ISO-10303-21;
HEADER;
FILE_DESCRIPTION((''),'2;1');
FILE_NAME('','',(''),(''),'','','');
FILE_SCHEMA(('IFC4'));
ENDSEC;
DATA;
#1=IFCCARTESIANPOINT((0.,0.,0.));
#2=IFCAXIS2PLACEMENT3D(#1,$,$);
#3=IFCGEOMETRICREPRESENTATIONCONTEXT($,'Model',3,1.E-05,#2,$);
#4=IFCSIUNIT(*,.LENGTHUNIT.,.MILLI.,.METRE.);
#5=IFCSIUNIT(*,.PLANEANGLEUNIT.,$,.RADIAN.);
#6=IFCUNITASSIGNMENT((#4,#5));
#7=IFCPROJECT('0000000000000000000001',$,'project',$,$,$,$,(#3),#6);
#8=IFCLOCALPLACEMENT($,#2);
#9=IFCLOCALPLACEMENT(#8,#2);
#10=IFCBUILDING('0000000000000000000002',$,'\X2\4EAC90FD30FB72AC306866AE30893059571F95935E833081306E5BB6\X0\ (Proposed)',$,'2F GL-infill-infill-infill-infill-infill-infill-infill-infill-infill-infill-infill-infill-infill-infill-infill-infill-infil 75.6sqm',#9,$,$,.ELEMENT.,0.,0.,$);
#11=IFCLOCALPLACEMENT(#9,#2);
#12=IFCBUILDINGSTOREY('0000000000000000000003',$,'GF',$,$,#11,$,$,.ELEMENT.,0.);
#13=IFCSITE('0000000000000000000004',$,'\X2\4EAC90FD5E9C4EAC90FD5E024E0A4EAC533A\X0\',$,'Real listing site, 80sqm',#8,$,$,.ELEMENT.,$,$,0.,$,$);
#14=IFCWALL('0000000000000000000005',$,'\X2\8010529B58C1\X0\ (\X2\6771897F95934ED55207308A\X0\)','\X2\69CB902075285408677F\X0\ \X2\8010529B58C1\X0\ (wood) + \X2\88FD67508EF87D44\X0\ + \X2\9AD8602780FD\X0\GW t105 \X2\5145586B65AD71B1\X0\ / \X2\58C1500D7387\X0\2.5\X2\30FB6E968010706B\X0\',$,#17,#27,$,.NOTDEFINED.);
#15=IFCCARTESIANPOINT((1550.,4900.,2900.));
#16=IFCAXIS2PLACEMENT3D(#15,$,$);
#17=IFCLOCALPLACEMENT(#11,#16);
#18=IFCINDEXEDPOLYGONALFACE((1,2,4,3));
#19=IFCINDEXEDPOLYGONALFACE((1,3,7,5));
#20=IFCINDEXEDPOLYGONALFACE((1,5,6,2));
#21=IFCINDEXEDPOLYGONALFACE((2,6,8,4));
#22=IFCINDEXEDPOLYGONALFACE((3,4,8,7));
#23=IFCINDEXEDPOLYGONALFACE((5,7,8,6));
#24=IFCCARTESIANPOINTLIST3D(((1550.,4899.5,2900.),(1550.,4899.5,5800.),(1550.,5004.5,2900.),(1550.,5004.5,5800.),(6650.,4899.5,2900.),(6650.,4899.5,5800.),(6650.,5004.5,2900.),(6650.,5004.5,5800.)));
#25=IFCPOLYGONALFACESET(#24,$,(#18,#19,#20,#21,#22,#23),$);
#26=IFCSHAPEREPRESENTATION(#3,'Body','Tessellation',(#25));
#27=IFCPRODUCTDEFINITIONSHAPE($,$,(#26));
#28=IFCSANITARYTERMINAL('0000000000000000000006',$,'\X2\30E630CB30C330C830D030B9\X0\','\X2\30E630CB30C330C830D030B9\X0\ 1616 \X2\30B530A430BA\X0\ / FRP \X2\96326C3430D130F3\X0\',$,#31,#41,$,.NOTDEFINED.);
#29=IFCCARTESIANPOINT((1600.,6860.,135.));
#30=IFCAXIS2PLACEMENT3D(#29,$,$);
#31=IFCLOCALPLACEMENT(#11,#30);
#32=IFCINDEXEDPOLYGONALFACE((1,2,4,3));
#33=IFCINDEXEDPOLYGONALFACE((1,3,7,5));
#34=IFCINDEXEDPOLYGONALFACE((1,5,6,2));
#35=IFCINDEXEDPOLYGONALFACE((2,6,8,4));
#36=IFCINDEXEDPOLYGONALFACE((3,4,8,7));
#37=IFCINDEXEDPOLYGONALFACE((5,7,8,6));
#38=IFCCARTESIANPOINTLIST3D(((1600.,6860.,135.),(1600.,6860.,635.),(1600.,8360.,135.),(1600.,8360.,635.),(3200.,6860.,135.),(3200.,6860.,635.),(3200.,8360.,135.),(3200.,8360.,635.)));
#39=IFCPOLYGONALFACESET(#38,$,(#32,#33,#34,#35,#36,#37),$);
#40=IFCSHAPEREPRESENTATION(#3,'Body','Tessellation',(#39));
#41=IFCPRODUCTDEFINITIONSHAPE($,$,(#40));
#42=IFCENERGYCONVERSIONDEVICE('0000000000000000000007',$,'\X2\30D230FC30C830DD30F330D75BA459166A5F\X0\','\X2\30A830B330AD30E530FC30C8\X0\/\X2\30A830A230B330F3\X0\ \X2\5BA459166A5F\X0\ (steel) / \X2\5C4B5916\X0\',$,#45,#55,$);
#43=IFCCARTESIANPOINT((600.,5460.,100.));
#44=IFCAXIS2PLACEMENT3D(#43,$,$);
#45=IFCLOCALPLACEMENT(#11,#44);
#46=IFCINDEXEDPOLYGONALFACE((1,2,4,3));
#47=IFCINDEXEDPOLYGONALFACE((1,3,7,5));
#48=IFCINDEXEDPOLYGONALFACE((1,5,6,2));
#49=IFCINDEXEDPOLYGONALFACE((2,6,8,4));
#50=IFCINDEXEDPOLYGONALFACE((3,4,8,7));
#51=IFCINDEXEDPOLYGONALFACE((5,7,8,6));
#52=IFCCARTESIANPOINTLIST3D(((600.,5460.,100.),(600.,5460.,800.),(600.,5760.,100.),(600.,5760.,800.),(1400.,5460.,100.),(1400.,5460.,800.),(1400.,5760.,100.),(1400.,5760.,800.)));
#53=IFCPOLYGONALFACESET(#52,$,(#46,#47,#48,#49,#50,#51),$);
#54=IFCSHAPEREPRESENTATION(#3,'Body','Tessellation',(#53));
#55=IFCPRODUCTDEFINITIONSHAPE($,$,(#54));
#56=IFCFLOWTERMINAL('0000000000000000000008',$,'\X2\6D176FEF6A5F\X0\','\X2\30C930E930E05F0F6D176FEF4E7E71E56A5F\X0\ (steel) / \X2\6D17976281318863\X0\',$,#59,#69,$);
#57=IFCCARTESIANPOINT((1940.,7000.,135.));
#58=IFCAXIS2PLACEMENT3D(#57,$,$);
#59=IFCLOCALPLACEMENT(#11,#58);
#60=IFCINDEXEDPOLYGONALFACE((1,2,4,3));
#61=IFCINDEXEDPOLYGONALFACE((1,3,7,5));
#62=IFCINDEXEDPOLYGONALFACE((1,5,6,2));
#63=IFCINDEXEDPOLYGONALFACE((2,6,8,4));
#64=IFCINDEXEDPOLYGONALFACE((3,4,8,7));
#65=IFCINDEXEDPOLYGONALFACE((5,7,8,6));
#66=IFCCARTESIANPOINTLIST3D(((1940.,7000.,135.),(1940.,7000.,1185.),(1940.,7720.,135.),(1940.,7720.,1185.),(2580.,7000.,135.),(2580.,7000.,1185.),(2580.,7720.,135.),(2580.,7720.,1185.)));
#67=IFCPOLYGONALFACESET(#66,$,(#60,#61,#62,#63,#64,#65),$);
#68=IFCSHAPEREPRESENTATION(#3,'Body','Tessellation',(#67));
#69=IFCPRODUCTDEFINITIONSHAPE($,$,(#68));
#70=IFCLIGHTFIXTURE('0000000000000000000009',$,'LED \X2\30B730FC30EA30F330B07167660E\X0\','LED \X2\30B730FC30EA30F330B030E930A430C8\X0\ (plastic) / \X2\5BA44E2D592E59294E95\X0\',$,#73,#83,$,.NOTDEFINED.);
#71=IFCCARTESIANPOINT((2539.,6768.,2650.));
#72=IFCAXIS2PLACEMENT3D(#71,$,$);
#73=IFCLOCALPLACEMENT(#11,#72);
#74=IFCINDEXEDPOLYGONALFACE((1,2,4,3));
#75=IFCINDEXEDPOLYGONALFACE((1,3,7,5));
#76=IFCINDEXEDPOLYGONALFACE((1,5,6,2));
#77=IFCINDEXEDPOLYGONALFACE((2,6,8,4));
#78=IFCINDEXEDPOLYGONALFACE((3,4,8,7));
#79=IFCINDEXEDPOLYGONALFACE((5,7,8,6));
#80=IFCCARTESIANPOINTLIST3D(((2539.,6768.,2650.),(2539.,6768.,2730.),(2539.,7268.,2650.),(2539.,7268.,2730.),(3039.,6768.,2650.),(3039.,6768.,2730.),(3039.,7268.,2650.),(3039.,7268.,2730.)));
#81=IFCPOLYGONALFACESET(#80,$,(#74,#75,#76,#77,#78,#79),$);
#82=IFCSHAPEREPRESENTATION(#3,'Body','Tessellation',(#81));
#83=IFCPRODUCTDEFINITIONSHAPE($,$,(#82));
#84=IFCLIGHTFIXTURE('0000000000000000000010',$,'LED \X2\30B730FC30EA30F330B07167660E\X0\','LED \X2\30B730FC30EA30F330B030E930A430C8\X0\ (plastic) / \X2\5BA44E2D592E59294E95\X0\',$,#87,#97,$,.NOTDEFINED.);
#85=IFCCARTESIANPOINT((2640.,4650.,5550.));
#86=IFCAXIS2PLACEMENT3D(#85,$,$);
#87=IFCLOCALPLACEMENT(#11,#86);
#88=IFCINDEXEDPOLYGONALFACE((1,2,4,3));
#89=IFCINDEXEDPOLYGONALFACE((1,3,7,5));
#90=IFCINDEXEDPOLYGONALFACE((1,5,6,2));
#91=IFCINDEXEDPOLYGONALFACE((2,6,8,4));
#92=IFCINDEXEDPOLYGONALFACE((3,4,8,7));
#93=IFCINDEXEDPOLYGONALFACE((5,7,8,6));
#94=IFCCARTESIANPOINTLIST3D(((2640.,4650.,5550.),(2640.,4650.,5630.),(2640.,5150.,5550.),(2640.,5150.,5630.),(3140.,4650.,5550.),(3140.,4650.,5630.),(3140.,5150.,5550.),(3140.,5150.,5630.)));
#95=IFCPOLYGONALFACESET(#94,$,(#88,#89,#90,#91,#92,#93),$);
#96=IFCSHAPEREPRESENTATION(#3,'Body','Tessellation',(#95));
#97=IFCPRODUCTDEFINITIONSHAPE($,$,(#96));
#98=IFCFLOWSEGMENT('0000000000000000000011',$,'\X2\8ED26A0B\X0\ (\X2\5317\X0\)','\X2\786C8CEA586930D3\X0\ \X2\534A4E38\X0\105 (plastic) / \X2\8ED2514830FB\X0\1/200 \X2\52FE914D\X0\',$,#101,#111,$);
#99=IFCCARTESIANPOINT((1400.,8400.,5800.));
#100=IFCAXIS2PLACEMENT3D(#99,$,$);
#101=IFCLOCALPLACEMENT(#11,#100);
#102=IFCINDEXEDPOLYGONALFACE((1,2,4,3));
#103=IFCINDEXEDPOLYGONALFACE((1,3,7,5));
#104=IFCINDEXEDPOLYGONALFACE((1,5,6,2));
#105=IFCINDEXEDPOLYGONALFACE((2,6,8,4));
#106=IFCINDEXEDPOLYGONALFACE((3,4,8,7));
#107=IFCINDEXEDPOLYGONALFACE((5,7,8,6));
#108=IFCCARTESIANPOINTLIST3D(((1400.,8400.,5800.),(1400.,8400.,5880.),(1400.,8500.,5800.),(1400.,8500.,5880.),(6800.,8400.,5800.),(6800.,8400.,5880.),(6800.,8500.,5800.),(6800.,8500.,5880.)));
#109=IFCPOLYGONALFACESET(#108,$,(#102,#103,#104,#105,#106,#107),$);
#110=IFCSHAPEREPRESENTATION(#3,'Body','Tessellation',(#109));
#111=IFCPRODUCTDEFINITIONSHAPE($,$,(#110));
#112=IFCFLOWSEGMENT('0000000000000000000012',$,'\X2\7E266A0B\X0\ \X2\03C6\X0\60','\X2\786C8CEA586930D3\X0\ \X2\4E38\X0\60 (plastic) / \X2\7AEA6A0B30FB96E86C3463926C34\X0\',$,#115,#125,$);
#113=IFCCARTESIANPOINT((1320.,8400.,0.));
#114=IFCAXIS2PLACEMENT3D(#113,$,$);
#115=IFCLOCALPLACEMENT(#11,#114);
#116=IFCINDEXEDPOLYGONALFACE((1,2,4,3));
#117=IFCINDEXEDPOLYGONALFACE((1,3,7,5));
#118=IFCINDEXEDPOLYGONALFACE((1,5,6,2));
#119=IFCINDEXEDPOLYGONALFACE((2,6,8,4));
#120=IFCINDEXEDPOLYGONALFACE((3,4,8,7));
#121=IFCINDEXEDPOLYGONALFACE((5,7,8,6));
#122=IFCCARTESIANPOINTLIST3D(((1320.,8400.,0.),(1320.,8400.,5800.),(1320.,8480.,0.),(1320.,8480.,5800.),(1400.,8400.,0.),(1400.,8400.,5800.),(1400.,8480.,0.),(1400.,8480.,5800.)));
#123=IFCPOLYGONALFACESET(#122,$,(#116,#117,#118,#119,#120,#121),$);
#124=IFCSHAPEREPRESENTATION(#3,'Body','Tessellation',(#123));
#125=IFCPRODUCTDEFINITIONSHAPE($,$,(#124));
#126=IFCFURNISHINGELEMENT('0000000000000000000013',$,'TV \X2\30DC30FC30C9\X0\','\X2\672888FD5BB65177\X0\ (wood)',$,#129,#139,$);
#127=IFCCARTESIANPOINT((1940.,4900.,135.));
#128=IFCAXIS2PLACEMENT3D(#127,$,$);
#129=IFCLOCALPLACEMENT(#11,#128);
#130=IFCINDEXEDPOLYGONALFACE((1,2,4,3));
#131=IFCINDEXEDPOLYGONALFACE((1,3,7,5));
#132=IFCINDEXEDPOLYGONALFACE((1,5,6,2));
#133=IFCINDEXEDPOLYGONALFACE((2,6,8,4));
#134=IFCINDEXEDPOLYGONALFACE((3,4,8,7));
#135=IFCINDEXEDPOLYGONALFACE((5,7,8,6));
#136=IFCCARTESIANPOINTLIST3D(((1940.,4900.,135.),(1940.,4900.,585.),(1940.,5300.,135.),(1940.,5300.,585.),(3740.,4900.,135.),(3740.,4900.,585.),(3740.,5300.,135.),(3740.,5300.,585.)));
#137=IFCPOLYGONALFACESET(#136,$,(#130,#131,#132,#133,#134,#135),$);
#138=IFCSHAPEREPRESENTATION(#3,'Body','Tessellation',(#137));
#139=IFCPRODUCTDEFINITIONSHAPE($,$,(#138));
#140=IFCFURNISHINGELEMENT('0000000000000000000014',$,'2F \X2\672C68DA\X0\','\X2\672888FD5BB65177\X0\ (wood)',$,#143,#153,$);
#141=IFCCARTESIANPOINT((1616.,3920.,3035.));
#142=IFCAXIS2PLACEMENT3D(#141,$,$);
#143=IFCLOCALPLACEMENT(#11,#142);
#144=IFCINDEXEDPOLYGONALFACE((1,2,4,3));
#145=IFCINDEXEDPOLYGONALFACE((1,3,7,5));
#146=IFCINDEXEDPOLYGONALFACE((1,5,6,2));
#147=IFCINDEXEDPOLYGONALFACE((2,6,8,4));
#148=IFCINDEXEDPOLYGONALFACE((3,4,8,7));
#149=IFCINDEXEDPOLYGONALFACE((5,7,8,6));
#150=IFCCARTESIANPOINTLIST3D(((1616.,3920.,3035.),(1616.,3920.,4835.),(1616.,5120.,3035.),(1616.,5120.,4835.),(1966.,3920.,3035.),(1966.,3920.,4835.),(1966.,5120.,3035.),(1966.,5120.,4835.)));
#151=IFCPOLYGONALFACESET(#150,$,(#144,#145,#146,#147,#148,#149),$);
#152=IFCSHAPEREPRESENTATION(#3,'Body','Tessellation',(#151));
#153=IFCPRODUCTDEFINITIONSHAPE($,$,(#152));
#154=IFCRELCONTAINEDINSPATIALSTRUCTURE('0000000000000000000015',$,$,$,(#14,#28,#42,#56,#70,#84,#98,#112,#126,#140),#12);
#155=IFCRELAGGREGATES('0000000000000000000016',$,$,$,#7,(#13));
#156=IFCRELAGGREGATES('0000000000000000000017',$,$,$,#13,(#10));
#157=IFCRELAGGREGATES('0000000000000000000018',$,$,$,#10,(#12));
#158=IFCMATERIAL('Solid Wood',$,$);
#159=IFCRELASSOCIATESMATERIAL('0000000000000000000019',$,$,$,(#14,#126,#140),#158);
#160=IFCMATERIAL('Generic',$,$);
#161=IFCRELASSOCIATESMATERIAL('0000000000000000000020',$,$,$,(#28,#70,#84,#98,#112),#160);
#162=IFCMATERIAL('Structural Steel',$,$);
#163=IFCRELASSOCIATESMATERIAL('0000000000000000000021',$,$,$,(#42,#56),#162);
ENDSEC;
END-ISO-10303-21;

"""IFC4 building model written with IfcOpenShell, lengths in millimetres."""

from ifc_helpers import new_model, si_unit, frame, frame_2d, origin, place, context, project, spatial, rectangle, extrude, material, element, save


model = new_model("IFC4")

# Units and contexts
model_context = context("Model", 3, precision=1e-05, world=origin())
ifc_project = project(units=[si_unit("LENGTHUNIT", "METRE", prefix="MILLI"), si_unit("PLANEANGLEUNIT", "RADIAN")], contexts=[model_context])

# Site, building, storey
site_placement = place(None, origin())
site = spatial("IfcSite", under=ifc_project, at=site_placement, Name="京都府京都市上京区", ObjectType="Real listing site, 80sqm", CompositionType="ELEMENT", RefElevation=0.0)
building_placement = place(site_placement, origin())
building = spatial("IfcBuilding", under=site, at=building_placement, Name="京都・犬と暮らす土間広めの家 (Proposed)", ObjectType="2F GL-infill-infill-infill-infill-infill-infill-infill-infill-infill-infill-infill-infill-infill-infill-infill-infill-infil 75.6sqm", CompositionType="ELEMENT", ElevationOfRefHeight=0.0, ElevationOfTerrain=0.0)
storey_placement = place(building_placement, origin())
storey = spatial("IfcBuildingStorey", under=building, at=storey_placement, Name="GF", CompositionType="ELEMENT", Elevation=0.0)

# Shared definitions
ifc_material_1 = material(Name="Solid Wood")

# Wall
wall_1_placement = place(storey_placement, frame((1550.0, 4900.0, 2900.0)))
element("IfcWall", 1, at=wall_1_placement, inside=storey, material=ifc_material_1, Name="耐力壁 (東西間仕切り)", Description="構造用合板 耐力壁 (wood) + 製材軸組 + 高性能GW t105 充填断熱 / 壁倍率2.5・準耐火", PredefinedType="NOTDEFINED", context=model_context, shape_type="SweptSolid", body=[
    extrude(rectangle(XDim=5100.0, YDim=105.0, at=frame_2d((2550.0, 52.0))), frame((1550.0, 4900.0, 2900.0)), (0.0, 0.0, 1.0), 2900.0),
])

# Sanitary terminal
ifc_material_2 = material(Name="Generic")
sanitary_terminal_placement = place(storey_placement, frame((1600.0, 6860.0, 135.0)))
element("IfcSanitaryTerminal", 2, at=sanitary_terminal_placement, inside=storey, material=ifc_material_2, Name="ユニットバス", Description="ユニットバス 1616 サイズ / FRP 防水パン", PredefinedType="NOTDEFINED", context=model_context, shape_type="SweptSolid", body=[
    extrude(rectangle(XDim=1600.0, YDim=1500.0, at=frame_2d((800.0, 750.0))), frame((1600.0, 6860.0, 135.0)), (0.0, 0.0, 1.0), 500.0),
])

# Shared definitions
ifc_material_3 = material(Name="Structural Steel")

# Energy conversion device
energy_conversion_device_placement = place(storey_placement, frame((600.0, 5460.0, 100.0)))
element("IfcEnergyConversionDevice", 3, at=energy_conversion_device_placement, inside=storey, material=ifc_material_3, Name="ヒートポンプ室外機", Description="エコキュート/エアコン 室外機 (steel) / 屋外", context=model_context, shape_type="SweptSolid", body=[
    extrude(rectangle(XDim=800.0, YDim=300.0, at=frame_2d((400.0, 150.0))), frame((600.0, 5460.0, 100.0)), (0.0, 0.0, 1.0), 700.0),
])

# Flow terminal
flow_terminal_placement = place(storey_placement, frame((1940.0, 7000.0, 135.0)))
element("IfcFlowTerminal", 4, at=flow_terminal_placement, inside=storey, material=ifc_material_3, Name="洗濯機", Description="ドラム式洗濯乾燥機 (steel) / 洗面脱衣", context=model_context, shape_type="SweptSolid", body=[
    extrude(rectangle(XDim=640.0, YDim=720.0, at=frame_2d((320.0, 360.0))), frame((1940.0, 7000.0, 135.0)), (0.0, 0.0, 1.0), 1050.0),
])

# Light fixtures
light_fixture_1_placement = place(storey_placement, frame((2539.0, 6768.0, 2650.0)))
element("IfcLightFixture", 5, at=light_fixture_1_placement, inside=storey, material=ifc_material_2, Name="LED シーリング照明", Description="LED シーリングライト (plastic) / 室中央天井", PredefinedType="NOTDEFINED", context=model_context, shape_type="SweptSolid", body=[
    extrude(rectangle(XDim=500.0, YDim=500.0, at=frame_2d((250.0, 250.0))), frame((2539.0, 6768.0, 2650.0)), (0.0, 0.0, 1.0), 80.0),
])
light_fixture_2_placement = place(storey_placement, frame((2640.0, 4650.0, 5550.0)))
element("IfcLightFixture", 6, at=light_fixture_2_placement, inside=storey, material=ifc_material_2, Name="LED シーリング照明", Description="LED シーリングライト (plastic) / 室中央天井", PredefinedType="NOTDEFINED", context=model_context, shape_type="SweptSolid", body=[
    extrude(rectangle(XDim=500.0, YDim=500.0, at=frame_2d((250.0, 250.0))), frame((2640.0, 4650.0, 5550.0)), (0.0, 0.0, 1.0), 80.0),
])

# Flow segments
flow_segment_1_placement = place(storey_placement, frame((1400.0, 8400.0, 5800.0)))
element("IfcFlowSegment", 7, at=flow_segment_1_placement, inside=storey, material=ifc_material_2, Name="軒樋 (北)", Description="硬質塩ビ 半丸105 (plastic) / 軒先・1/200 勾配", context=model_context, shape_type="SweptSolid", body=[
    extrude(rectangle(XDim=5400.0, YDim=100.0, at=frame_2d((2700.0, 50.0))), frame((1400.0, 8400.0, 5800.0)), (0.0, 0.0, 1.0), 80.0),
])
flow_segment_2_placement = place(storey_placement, frame((1320.0, 8400.0, 0.0)))
element("IfcFlowSegment", 8, at=flow_segment_2_placement, inside=storey, material=ifc_material_2, Name="縦樋 φ60", Description="硬質塩ビ 丸60 (plastic) / 竪樋・雨水排水", context=model_context, shape_type="SweptSolid", body=[
    extrude(rectangle(XDim=80.0, YDim=80.0, at=frame_2d((40.0, 40.0))), frame((1320.0, 8400.0, 0.0)), (0.0, 0.0, 1.0), 5800.0),
])

# Furnishing elements
furnishing_1_placement = place(storey_placement, frame((1940.0, 4900.0, 135.0)))
element("IfcFurnishingElement", 9, at=furnishing_1_placement, inside=storey, material=ifc_material_1, Name="TV ボード", Description="木製家具 (wood)", context=model_context, shape_type="SweptSolid", body=[
    extrude(rectangle(XDim=1800.0, YDim=400.0, at=frame_2d((900.0, 200.0))), frame((1940.0, 4900.0, 135.0)), (0.0, 0.0, 1.0), 450.0),
])
furnishing_2_placement = place(storey_placement, frame((1616.0, 3920.0, 3035.0)))
element("IfcFurnishingElement", 10, at=furnishing_2_placement, inside=storey, material=ifc_material_1, Name="2F 本棚", Description="木製家具 (wood)", context=model_context, shape_type="SweptSolid", body=[
    extrude(rectangle(XDim=350.0, YDim=1200.0, at=frame_2d((175.0, 600.0))), frame((1616.0, 3920.0, 3035.0)), (0.0, 0.0, 1.0), 1800.0),
])

save(model, "model.ifc")
